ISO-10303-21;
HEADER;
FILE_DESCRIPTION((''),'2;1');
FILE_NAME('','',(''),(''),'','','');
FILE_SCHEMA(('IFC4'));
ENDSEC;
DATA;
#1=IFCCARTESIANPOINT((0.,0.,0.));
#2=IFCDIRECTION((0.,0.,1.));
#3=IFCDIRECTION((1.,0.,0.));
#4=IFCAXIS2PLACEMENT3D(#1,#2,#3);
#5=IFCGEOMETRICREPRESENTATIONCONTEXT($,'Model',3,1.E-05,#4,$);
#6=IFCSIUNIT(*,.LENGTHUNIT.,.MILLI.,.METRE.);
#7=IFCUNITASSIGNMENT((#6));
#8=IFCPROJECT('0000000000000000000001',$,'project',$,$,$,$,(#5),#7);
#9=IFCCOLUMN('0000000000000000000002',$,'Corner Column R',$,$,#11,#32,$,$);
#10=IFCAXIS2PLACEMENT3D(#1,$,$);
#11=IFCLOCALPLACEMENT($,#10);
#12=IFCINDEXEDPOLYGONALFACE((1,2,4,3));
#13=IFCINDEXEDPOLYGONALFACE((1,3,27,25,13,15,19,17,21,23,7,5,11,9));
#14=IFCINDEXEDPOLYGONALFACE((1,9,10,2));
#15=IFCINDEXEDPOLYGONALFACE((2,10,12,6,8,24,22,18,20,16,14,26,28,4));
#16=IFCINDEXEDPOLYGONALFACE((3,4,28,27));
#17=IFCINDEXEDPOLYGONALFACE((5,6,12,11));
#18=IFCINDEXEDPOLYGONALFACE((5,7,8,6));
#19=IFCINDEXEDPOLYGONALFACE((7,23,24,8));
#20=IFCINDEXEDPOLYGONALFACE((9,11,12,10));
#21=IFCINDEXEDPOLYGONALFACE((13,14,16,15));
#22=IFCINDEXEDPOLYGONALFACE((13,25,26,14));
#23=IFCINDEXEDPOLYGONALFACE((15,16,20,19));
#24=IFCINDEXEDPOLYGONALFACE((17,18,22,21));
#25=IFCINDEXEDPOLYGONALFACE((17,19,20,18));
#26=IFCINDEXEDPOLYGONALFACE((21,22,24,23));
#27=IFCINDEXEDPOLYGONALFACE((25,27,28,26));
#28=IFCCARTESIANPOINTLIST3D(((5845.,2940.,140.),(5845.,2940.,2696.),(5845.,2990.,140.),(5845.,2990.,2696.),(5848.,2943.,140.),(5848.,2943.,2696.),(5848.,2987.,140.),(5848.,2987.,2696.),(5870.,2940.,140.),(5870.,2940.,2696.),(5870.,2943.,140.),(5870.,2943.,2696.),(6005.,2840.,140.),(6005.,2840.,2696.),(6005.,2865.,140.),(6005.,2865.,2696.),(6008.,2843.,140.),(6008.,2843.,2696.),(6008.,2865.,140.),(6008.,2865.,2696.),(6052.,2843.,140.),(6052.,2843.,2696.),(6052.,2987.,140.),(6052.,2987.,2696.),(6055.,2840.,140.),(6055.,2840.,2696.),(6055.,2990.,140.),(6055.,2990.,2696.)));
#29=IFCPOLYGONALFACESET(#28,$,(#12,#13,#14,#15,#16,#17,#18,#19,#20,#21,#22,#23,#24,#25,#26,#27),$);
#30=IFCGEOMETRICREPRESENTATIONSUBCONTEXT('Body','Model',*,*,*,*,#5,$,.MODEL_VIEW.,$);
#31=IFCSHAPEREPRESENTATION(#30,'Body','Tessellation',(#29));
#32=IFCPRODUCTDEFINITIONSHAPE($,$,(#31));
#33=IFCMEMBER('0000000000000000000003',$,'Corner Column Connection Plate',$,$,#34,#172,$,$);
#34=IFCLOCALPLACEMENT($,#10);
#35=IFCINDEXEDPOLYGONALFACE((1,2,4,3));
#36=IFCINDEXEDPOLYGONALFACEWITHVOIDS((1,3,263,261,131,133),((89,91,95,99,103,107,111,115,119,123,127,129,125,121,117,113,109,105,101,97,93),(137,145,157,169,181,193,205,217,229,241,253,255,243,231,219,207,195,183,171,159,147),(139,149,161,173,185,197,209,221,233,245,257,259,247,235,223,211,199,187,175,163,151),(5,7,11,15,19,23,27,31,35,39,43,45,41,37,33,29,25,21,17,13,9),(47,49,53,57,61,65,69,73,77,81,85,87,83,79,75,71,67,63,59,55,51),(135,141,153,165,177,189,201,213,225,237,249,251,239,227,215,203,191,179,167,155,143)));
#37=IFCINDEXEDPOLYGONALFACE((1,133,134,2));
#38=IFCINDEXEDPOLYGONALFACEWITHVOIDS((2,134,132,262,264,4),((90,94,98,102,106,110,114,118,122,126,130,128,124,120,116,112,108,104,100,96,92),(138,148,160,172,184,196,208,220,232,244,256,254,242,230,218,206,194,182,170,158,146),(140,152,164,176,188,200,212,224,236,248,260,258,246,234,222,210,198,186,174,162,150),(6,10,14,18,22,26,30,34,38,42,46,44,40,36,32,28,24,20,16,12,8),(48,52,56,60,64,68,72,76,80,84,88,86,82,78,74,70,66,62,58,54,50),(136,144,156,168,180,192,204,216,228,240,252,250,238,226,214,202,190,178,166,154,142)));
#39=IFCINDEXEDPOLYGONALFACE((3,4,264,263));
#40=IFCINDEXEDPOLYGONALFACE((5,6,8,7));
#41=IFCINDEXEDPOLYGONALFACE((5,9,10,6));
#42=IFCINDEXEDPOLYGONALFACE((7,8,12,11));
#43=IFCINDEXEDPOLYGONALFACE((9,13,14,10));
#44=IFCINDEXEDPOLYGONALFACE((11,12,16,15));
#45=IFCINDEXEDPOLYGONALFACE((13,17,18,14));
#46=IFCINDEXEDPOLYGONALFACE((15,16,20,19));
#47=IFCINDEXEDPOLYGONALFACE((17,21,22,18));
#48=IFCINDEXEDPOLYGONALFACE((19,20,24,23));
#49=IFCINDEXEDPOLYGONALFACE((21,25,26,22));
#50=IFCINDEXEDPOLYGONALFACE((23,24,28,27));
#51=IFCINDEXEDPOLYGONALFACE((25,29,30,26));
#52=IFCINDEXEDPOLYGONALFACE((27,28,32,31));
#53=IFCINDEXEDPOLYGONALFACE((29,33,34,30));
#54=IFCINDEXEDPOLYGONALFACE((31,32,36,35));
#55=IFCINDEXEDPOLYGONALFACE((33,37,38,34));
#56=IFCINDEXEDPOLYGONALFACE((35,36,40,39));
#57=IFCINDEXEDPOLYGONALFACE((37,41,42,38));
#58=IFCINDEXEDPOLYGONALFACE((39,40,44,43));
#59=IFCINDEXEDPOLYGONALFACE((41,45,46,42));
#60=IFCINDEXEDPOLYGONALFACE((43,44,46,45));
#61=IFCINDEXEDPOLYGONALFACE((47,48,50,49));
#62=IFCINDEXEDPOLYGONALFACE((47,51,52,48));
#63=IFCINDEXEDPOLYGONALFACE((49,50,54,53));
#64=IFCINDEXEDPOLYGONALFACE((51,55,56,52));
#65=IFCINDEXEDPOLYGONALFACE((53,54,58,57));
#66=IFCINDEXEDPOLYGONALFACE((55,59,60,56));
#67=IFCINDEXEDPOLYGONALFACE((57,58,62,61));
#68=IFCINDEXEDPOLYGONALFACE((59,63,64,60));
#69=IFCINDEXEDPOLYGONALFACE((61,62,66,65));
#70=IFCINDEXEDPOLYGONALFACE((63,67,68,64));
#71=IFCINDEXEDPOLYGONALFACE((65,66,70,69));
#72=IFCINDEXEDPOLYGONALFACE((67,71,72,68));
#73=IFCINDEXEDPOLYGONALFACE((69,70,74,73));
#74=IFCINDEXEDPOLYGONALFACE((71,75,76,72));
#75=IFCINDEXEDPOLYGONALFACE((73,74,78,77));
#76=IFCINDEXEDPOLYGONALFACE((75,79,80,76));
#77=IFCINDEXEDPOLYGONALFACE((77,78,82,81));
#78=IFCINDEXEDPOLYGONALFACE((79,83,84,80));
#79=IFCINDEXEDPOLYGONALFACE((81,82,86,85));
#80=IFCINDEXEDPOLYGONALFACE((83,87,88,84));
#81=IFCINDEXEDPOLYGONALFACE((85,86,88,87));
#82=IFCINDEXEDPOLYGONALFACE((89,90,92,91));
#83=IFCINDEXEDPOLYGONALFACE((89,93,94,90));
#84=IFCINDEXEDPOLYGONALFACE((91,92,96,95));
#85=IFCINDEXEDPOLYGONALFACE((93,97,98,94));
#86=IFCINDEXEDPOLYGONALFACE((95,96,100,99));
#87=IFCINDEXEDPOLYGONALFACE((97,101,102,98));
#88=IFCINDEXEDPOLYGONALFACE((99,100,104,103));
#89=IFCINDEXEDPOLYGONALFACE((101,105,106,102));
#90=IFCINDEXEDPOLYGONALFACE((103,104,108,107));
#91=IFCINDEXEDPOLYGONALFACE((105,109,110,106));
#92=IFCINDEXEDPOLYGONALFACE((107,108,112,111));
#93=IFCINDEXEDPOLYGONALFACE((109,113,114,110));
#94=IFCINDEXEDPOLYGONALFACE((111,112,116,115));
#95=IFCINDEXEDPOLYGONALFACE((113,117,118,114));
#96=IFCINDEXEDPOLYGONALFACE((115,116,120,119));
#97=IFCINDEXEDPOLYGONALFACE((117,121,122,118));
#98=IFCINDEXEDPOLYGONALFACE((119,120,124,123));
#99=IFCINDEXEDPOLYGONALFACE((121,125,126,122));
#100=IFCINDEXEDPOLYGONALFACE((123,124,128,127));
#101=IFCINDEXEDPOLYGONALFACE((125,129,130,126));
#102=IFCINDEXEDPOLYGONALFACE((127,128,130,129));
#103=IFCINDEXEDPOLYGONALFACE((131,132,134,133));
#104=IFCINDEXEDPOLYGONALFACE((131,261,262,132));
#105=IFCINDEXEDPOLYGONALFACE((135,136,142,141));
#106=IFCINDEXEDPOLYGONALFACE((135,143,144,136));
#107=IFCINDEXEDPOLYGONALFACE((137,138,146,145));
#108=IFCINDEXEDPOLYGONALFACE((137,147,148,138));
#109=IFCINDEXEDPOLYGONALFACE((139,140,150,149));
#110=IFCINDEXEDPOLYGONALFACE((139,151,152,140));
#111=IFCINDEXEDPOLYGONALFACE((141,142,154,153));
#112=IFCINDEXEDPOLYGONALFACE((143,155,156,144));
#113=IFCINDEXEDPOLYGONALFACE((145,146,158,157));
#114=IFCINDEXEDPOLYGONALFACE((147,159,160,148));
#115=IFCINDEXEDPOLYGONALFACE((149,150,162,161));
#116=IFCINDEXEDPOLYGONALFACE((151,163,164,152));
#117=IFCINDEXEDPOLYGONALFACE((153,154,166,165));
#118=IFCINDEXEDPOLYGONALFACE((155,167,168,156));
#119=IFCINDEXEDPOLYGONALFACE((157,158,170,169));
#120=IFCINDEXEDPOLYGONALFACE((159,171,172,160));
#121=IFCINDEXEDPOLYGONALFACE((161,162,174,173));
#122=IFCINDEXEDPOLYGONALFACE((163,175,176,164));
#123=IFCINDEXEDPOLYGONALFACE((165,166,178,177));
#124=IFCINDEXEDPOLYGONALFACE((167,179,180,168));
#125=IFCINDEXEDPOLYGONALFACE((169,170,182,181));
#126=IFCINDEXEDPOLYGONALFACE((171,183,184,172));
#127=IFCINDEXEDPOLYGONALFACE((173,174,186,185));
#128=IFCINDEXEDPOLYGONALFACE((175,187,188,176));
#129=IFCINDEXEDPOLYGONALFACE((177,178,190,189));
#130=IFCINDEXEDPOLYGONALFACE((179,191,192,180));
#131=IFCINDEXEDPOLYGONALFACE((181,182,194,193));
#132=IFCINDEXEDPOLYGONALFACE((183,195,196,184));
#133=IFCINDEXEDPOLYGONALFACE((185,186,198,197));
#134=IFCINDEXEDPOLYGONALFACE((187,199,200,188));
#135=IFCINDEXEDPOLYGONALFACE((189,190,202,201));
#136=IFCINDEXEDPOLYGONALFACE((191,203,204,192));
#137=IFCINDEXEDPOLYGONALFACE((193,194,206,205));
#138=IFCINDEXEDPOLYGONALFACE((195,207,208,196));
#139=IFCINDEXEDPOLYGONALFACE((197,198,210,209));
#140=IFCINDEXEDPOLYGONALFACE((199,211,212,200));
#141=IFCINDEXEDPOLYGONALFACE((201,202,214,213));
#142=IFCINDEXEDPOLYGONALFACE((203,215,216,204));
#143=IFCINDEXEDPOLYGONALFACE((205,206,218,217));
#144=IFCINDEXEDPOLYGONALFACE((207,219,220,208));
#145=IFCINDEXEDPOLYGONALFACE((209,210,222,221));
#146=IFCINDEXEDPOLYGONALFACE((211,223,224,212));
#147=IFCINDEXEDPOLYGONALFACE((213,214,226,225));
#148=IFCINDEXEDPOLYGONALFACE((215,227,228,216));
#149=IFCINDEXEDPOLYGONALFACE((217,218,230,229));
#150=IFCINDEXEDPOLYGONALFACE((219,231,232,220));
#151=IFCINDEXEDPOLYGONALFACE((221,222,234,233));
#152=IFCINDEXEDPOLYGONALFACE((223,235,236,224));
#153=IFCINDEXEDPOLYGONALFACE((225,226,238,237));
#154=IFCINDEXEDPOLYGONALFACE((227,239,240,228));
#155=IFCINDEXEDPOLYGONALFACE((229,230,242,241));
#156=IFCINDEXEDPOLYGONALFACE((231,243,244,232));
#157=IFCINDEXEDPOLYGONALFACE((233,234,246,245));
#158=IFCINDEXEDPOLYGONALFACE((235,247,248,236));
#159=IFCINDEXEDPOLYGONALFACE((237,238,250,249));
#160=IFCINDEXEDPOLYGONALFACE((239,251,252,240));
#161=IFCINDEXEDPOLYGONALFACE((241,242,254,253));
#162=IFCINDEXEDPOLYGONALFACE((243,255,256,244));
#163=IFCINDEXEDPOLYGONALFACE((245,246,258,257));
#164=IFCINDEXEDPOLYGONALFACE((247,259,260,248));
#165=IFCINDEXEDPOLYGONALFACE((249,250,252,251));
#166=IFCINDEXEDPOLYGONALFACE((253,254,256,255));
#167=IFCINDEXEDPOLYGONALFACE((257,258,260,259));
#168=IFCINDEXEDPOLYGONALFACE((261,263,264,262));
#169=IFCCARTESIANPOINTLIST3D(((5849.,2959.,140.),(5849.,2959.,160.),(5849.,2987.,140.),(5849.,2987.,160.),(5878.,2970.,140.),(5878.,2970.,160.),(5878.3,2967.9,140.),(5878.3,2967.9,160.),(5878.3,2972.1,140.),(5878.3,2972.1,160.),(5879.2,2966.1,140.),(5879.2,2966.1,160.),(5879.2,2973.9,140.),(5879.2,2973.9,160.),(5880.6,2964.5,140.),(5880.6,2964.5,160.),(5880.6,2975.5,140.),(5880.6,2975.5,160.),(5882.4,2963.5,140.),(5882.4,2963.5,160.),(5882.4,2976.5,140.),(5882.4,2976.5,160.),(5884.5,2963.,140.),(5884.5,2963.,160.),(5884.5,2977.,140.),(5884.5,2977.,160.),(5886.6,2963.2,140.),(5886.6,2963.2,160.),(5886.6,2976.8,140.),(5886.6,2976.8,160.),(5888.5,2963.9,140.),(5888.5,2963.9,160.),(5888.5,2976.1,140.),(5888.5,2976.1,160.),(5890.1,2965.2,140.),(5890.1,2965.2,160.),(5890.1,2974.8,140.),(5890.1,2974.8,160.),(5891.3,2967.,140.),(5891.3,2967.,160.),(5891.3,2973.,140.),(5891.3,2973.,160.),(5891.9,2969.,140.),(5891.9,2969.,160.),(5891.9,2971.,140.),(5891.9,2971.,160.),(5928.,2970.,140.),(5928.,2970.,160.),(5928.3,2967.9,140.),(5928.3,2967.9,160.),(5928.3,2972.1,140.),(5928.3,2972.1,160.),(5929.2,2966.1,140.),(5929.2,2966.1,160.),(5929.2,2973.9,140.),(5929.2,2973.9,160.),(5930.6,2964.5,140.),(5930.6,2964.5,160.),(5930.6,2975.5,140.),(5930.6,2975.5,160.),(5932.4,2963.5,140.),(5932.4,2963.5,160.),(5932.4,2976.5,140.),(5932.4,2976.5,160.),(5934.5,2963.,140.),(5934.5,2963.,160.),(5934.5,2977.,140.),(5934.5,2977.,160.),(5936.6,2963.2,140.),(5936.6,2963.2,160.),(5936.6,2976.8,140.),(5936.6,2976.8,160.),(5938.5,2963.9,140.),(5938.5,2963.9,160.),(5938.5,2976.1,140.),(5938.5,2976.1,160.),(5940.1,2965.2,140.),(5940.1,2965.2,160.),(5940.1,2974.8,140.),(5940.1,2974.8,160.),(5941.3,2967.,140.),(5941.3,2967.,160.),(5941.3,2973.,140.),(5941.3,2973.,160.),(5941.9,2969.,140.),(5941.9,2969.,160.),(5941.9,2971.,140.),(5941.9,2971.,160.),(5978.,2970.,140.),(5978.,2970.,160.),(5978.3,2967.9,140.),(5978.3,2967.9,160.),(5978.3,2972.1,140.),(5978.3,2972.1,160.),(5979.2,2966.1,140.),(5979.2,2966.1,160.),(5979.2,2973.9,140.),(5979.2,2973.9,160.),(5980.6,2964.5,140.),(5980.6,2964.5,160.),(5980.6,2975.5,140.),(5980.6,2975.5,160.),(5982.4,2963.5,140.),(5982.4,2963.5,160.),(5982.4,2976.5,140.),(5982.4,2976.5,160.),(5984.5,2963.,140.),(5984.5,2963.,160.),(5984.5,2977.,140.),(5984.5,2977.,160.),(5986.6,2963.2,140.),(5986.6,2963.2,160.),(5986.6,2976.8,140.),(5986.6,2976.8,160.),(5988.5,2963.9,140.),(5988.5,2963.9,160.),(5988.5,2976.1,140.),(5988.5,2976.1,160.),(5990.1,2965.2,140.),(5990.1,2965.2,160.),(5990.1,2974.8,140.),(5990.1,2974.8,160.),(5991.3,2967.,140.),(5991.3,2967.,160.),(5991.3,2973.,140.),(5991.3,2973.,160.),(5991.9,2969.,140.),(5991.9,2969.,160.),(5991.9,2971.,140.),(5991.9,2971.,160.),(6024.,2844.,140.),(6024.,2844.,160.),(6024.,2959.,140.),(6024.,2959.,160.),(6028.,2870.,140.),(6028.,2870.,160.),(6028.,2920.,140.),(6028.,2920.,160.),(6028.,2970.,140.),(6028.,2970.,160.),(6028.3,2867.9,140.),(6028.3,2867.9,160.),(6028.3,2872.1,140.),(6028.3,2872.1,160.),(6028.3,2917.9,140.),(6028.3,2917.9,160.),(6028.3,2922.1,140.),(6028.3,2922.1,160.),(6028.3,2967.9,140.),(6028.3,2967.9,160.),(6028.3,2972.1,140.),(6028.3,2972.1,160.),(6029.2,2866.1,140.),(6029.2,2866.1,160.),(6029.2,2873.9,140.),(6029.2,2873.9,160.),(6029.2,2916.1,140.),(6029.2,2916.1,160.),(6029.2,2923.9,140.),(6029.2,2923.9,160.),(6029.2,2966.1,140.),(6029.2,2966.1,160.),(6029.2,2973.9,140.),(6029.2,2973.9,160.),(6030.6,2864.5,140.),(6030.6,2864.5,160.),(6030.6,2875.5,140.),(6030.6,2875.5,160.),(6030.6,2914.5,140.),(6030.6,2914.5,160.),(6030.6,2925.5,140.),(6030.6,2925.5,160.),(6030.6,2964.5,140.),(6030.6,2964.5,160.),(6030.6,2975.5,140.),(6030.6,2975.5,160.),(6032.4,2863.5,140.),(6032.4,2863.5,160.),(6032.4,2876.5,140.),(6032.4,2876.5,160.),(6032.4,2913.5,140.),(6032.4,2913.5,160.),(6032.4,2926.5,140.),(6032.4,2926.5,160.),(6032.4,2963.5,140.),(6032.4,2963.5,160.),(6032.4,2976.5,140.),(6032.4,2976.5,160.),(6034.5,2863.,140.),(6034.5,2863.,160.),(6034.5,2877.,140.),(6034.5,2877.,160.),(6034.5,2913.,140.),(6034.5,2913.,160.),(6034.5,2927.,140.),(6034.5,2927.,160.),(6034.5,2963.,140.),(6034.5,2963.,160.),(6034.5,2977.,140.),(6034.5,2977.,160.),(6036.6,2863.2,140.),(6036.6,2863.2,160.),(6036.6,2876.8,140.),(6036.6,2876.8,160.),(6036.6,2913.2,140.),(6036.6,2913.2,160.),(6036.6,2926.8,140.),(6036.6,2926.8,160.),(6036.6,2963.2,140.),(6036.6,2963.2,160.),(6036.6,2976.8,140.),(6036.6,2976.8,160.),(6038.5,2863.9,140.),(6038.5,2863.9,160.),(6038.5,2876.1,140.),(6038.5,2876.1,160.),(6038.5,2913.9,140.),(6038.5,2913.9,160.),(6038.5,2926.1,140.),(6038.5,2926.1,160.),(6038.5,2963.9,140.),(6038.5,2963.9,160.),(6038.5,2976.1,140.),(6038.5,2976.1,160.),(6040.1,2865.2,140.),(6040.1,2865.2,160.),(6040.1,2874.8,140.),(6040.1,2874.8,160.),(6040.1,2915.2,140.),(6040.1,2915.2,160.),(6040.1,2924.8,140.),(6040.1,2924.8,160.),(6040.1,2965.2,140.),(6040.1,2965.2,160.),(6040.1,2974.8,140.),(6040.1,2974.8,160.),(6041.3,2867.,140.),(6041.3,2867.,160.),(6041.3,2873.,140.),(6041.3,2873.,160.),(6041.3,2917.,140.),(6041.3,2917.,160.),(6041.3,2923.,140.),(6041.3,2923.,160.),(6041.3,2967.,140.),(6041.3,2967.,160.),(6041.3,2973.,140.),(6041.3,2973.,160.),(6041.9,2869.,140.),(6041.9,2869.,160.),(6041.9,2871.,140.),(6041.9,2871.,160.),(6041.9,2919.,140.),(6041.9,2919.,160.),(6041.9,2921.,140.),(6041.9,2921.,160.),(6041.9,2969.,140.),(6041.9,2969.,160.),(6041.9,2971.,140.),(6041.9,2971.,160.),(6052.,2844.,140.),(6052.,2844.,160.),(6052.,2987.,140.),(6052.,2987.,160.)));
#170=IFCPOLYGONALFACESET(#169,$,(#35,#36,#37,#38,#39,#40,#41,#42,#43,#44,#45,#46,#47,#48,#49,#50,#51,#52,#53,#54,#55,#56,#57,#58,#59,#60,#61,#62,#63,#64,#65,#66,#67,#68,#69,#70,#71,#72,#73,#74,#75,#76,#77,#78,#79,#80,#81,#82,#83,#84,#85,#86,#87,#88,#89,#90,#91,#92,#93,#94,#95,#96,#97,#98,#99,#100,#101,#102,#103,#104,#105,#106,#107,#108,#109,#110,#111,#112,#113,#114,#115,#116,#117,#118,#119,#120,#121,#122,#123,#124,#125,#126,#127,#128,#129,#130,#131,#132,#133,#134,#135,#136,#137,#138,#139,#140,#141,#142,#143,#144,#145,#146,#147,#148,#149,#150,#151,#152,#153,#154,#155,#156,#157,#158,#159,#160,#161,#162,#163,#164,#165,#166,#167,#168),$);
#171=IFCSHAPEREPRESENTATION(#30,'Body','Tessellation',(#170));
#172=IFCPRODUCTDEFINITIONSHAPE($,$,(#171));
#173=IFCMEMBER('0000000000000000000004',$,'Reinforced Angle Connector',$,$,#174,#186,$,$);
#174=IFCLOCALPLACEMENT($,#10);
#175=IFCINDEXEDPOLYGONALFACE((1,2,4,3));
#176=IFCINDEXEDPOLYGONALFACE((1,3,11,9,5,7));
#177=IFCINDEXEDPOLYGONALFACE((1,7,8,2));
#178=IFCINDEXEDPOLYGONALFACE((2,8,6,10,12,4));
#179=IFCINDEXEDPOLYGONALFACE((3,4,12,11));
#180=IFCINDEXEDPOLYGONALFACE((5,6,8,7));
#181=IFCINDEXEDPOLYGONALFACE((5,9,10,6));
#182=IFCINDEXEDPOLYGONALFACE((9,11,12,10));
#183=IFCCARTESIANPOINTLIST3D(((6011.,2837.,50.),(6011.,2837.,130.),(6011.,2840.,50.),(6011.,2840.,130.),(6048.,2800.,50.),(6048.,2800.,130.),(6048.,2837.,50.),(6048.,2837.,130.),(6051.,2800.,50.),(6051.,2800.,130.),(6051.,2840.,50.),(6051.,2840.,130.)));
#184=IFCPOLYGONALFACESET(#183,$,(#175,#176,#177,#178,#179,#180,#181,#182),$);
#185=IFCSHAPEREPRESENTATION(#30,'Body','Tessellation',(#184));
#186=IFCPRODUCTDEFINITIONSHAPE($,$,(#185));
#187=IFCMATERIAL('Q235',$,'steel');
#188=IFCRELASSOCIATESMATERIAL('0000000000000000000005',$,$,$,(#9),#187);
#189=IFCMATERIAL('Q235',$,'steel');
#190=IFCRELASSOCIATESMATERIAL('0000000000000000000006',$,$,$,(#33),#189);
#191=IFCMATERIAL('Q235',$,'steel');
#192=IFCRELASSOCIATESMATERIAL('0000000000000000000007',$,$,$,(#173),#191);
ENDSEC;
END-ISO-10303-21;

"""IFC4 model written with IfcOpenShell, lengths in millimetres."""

from ifc_helpers import new_model, si_unit, frame, origin_with_axes, origin_2d, place, context, subcontext, project, line, indexed_curve, circle_curve, outline, extrude, material, element, save


model = new_model("IFC4")

# Units and contexts
model_context = context("Model", 3, precision=1e-05, world=origin_with_axes())
body_context = subcontext(model_context, "Body", "Model", "MODEL_VIEW")
ifc_project = project(units=[si_unit("LENGTHUNIT", "METRE", prefix="MILLI")], contexts=[model_context])

# Column
ifc_material_1 = material(Name="Q235", Category="steel")
column_placement = place(None, frame((6055.0, 2990.0, 140.0), z_axis=(0.0, 0.0, 1.0), x_axis=(0.0, -1.0, 0.0)))
element("IfcColumn", 1, at=column_placement, material=ifc_material_1, Name="Corner Column R", context=body_context, shape_type="SweptSolid", body=[
    extrude(outline(indexed_curve([(0.0, 0.0), (0.0, -210.0), (50.0, -210.0), (50.0, -185.0), (47.0, -185.0), (47.0, -207.0), (3.0, -207.0), (3.0, -3.0), (147.0, -3.0), (147.0, -47.0), (125.0, -47.0), (125.0, -50.0), (150.0, -50.0), (150.0, 0.0), (0.0, 0.0)], segments=[line(1, 2, 3, 4, 5, 6, 7, 8, 9, 10, 11, 12, 13, 14, 15, 1)])), origin_with_axes(), (0.0, 0.0, 1.0), 2556.0),
])

# Member, openings
ifc_material_2 = material(Name="Q235", Category="steel")
member_1_placement = place(None, frame((6052.0, 2987.0, 140.0), z_axis=(0.0, 0.0, 1.0), x_axis=(-1.0, 0.0, 0.0)))
member_1 = element("IfcMember", 2, at=member_1_placement, material=ifc_material_2, Name="Corner Column Connection Plate", context=body_context, shape_type="SweptSolid", body=[
    extrude(outline(indexed_curve([(0.0, 0.0), (203.0, 0.0), (203.0, 28.0), (28.0, 28.0), (28.0, 143.0), (0.0, 143.0), (0.0, 0.0)], segments=[line(1, 2, 3, 4, 5, 6, 7, 1)])), origin_with_axes(), (0.0, 0.0, 1.0), 20.0),
])
opening_1_placement = place(member_1_placement, frame((17.0, 17.0, 0.0), z_axis=(0.0, 0.0, 1.0), x_axis=(1.0, 0.0, 0.0)))
element("IfcOpeningElement", 3, at=opening_1_placement, cuts=member_1, context=body_context, shape_type="SweptSolid", body=[
    extrude(outline(circle_curve(origin_2d(), 7.0)), origin_with_axes(), (0.0, 0.0, 1.0), 20.0),
])
opening_2_placement = place(member_1_placement, frame((67.0, 17.0, 0.0), z_axis=(0.0, 0.0, 1.0), x_axis=(1.0, 0.0, 0.0)))
element("IfcOpeningElement", 4, at=opening_2_placement, cuts=member_1, context=body_context, shape_type="SweptSolid", body=[
    extrude(outline(circle_curve(origin_2d(), 7.0)), origin_with_axes(), (0.0, 0.0, 1.0), 20.0),
])
opening_3_placement = place(member_1_placement, frame((117.0, 17.0, 0.0), z_axis=(0.0, 0.0, 1.0), x_axis=(1.0, 0.0, 0.0)))
element("IfcOpeningElement", 5, at=opening_3_placement, cuts=member_1, context=body_context, shape_type="SweptSolid", body=[
    extrude(outline(circle_curve(origin_2d(), 7.0)), origin_with_axes(), (0.0, 0.0, 1.0), 20.0),
])
opening_4_placement = place(member_1_placement, frame((167.0, 17.0, 0.0), z_axis=(0.0, 0.0, 1.0), x_axis=(1.0, 0.0, 0.0)))
element("IfcOpeningElement", 6, at=opening_4_placement, cuts=member_1, context=body_context, shape_type="SweptSolid", body=[
    extrude(outline(circle_curve(origin_2d(), 7.0)), origin_with_axes(), (0.0, 0.0, 1.0), 20.0),
])
opening_5_placement = place(member_1_placement, frame((17.0, 67.0, 0.0), z_axis=(0.0, 0.0, 1.0), x_axis=(1.0, 0.0, 0.0)))
element("IfcOpeningElement", 7, at=opening_5_placement, cuts=member_1, context=body_context, shape_type="SweptSolid", body=[
    extrude(outline(circle_curve(origin_2d(), 7.0)), origin_with_axes(), (0.0, 0.0, 1.0), 20.0),
])
opening_6_placement = place(member_1_placement, frame((17.0, 117.0, 0.0), z_axis=(0.0, 0.0, 1.0), x_axis=(1.0, 0.0, 0.0)))
element("IfcOpeningElement", 8, at=opening_6_placement, cuts=member_1, context=body_context, shape_type="SweptSolid", body=[
    extrude(outline(circle_curve(origin_2d(), 7.0)), origin_with_axes(), (0.0, 0.0, 1.0), 20.0),
])

# Member
ifc_material_3 = material(Name="Q235", Category="steel")
member_2_placement = place(None, frame((6051.0, 2840.0, 50.0), z_axis=(0.0, 0.0, 1.0), x_axis=(-1.0, 0.0, 0.0)))
element("IfcMember", 9, at=member_2_placement, material=ifc_material_3, Name="Reinforced Angle Connector", context=body_context, shape_type="SweptSolid", body=[
    extrude(outline(indexed_curve([(0.0, 0.0), (0.0, 40.0), (3.0, 40.0), (3.0, 3.0), (40.0, 3.0), (40.0, 0.0), (0.0, 0.0)], segments=[line(1, 2, 3, 4, 5, 6, 7, 1)])), origin_with_axes(), (0.0, 0.0, 1.0), 80.0),
])

save(model, "model.ifc")
